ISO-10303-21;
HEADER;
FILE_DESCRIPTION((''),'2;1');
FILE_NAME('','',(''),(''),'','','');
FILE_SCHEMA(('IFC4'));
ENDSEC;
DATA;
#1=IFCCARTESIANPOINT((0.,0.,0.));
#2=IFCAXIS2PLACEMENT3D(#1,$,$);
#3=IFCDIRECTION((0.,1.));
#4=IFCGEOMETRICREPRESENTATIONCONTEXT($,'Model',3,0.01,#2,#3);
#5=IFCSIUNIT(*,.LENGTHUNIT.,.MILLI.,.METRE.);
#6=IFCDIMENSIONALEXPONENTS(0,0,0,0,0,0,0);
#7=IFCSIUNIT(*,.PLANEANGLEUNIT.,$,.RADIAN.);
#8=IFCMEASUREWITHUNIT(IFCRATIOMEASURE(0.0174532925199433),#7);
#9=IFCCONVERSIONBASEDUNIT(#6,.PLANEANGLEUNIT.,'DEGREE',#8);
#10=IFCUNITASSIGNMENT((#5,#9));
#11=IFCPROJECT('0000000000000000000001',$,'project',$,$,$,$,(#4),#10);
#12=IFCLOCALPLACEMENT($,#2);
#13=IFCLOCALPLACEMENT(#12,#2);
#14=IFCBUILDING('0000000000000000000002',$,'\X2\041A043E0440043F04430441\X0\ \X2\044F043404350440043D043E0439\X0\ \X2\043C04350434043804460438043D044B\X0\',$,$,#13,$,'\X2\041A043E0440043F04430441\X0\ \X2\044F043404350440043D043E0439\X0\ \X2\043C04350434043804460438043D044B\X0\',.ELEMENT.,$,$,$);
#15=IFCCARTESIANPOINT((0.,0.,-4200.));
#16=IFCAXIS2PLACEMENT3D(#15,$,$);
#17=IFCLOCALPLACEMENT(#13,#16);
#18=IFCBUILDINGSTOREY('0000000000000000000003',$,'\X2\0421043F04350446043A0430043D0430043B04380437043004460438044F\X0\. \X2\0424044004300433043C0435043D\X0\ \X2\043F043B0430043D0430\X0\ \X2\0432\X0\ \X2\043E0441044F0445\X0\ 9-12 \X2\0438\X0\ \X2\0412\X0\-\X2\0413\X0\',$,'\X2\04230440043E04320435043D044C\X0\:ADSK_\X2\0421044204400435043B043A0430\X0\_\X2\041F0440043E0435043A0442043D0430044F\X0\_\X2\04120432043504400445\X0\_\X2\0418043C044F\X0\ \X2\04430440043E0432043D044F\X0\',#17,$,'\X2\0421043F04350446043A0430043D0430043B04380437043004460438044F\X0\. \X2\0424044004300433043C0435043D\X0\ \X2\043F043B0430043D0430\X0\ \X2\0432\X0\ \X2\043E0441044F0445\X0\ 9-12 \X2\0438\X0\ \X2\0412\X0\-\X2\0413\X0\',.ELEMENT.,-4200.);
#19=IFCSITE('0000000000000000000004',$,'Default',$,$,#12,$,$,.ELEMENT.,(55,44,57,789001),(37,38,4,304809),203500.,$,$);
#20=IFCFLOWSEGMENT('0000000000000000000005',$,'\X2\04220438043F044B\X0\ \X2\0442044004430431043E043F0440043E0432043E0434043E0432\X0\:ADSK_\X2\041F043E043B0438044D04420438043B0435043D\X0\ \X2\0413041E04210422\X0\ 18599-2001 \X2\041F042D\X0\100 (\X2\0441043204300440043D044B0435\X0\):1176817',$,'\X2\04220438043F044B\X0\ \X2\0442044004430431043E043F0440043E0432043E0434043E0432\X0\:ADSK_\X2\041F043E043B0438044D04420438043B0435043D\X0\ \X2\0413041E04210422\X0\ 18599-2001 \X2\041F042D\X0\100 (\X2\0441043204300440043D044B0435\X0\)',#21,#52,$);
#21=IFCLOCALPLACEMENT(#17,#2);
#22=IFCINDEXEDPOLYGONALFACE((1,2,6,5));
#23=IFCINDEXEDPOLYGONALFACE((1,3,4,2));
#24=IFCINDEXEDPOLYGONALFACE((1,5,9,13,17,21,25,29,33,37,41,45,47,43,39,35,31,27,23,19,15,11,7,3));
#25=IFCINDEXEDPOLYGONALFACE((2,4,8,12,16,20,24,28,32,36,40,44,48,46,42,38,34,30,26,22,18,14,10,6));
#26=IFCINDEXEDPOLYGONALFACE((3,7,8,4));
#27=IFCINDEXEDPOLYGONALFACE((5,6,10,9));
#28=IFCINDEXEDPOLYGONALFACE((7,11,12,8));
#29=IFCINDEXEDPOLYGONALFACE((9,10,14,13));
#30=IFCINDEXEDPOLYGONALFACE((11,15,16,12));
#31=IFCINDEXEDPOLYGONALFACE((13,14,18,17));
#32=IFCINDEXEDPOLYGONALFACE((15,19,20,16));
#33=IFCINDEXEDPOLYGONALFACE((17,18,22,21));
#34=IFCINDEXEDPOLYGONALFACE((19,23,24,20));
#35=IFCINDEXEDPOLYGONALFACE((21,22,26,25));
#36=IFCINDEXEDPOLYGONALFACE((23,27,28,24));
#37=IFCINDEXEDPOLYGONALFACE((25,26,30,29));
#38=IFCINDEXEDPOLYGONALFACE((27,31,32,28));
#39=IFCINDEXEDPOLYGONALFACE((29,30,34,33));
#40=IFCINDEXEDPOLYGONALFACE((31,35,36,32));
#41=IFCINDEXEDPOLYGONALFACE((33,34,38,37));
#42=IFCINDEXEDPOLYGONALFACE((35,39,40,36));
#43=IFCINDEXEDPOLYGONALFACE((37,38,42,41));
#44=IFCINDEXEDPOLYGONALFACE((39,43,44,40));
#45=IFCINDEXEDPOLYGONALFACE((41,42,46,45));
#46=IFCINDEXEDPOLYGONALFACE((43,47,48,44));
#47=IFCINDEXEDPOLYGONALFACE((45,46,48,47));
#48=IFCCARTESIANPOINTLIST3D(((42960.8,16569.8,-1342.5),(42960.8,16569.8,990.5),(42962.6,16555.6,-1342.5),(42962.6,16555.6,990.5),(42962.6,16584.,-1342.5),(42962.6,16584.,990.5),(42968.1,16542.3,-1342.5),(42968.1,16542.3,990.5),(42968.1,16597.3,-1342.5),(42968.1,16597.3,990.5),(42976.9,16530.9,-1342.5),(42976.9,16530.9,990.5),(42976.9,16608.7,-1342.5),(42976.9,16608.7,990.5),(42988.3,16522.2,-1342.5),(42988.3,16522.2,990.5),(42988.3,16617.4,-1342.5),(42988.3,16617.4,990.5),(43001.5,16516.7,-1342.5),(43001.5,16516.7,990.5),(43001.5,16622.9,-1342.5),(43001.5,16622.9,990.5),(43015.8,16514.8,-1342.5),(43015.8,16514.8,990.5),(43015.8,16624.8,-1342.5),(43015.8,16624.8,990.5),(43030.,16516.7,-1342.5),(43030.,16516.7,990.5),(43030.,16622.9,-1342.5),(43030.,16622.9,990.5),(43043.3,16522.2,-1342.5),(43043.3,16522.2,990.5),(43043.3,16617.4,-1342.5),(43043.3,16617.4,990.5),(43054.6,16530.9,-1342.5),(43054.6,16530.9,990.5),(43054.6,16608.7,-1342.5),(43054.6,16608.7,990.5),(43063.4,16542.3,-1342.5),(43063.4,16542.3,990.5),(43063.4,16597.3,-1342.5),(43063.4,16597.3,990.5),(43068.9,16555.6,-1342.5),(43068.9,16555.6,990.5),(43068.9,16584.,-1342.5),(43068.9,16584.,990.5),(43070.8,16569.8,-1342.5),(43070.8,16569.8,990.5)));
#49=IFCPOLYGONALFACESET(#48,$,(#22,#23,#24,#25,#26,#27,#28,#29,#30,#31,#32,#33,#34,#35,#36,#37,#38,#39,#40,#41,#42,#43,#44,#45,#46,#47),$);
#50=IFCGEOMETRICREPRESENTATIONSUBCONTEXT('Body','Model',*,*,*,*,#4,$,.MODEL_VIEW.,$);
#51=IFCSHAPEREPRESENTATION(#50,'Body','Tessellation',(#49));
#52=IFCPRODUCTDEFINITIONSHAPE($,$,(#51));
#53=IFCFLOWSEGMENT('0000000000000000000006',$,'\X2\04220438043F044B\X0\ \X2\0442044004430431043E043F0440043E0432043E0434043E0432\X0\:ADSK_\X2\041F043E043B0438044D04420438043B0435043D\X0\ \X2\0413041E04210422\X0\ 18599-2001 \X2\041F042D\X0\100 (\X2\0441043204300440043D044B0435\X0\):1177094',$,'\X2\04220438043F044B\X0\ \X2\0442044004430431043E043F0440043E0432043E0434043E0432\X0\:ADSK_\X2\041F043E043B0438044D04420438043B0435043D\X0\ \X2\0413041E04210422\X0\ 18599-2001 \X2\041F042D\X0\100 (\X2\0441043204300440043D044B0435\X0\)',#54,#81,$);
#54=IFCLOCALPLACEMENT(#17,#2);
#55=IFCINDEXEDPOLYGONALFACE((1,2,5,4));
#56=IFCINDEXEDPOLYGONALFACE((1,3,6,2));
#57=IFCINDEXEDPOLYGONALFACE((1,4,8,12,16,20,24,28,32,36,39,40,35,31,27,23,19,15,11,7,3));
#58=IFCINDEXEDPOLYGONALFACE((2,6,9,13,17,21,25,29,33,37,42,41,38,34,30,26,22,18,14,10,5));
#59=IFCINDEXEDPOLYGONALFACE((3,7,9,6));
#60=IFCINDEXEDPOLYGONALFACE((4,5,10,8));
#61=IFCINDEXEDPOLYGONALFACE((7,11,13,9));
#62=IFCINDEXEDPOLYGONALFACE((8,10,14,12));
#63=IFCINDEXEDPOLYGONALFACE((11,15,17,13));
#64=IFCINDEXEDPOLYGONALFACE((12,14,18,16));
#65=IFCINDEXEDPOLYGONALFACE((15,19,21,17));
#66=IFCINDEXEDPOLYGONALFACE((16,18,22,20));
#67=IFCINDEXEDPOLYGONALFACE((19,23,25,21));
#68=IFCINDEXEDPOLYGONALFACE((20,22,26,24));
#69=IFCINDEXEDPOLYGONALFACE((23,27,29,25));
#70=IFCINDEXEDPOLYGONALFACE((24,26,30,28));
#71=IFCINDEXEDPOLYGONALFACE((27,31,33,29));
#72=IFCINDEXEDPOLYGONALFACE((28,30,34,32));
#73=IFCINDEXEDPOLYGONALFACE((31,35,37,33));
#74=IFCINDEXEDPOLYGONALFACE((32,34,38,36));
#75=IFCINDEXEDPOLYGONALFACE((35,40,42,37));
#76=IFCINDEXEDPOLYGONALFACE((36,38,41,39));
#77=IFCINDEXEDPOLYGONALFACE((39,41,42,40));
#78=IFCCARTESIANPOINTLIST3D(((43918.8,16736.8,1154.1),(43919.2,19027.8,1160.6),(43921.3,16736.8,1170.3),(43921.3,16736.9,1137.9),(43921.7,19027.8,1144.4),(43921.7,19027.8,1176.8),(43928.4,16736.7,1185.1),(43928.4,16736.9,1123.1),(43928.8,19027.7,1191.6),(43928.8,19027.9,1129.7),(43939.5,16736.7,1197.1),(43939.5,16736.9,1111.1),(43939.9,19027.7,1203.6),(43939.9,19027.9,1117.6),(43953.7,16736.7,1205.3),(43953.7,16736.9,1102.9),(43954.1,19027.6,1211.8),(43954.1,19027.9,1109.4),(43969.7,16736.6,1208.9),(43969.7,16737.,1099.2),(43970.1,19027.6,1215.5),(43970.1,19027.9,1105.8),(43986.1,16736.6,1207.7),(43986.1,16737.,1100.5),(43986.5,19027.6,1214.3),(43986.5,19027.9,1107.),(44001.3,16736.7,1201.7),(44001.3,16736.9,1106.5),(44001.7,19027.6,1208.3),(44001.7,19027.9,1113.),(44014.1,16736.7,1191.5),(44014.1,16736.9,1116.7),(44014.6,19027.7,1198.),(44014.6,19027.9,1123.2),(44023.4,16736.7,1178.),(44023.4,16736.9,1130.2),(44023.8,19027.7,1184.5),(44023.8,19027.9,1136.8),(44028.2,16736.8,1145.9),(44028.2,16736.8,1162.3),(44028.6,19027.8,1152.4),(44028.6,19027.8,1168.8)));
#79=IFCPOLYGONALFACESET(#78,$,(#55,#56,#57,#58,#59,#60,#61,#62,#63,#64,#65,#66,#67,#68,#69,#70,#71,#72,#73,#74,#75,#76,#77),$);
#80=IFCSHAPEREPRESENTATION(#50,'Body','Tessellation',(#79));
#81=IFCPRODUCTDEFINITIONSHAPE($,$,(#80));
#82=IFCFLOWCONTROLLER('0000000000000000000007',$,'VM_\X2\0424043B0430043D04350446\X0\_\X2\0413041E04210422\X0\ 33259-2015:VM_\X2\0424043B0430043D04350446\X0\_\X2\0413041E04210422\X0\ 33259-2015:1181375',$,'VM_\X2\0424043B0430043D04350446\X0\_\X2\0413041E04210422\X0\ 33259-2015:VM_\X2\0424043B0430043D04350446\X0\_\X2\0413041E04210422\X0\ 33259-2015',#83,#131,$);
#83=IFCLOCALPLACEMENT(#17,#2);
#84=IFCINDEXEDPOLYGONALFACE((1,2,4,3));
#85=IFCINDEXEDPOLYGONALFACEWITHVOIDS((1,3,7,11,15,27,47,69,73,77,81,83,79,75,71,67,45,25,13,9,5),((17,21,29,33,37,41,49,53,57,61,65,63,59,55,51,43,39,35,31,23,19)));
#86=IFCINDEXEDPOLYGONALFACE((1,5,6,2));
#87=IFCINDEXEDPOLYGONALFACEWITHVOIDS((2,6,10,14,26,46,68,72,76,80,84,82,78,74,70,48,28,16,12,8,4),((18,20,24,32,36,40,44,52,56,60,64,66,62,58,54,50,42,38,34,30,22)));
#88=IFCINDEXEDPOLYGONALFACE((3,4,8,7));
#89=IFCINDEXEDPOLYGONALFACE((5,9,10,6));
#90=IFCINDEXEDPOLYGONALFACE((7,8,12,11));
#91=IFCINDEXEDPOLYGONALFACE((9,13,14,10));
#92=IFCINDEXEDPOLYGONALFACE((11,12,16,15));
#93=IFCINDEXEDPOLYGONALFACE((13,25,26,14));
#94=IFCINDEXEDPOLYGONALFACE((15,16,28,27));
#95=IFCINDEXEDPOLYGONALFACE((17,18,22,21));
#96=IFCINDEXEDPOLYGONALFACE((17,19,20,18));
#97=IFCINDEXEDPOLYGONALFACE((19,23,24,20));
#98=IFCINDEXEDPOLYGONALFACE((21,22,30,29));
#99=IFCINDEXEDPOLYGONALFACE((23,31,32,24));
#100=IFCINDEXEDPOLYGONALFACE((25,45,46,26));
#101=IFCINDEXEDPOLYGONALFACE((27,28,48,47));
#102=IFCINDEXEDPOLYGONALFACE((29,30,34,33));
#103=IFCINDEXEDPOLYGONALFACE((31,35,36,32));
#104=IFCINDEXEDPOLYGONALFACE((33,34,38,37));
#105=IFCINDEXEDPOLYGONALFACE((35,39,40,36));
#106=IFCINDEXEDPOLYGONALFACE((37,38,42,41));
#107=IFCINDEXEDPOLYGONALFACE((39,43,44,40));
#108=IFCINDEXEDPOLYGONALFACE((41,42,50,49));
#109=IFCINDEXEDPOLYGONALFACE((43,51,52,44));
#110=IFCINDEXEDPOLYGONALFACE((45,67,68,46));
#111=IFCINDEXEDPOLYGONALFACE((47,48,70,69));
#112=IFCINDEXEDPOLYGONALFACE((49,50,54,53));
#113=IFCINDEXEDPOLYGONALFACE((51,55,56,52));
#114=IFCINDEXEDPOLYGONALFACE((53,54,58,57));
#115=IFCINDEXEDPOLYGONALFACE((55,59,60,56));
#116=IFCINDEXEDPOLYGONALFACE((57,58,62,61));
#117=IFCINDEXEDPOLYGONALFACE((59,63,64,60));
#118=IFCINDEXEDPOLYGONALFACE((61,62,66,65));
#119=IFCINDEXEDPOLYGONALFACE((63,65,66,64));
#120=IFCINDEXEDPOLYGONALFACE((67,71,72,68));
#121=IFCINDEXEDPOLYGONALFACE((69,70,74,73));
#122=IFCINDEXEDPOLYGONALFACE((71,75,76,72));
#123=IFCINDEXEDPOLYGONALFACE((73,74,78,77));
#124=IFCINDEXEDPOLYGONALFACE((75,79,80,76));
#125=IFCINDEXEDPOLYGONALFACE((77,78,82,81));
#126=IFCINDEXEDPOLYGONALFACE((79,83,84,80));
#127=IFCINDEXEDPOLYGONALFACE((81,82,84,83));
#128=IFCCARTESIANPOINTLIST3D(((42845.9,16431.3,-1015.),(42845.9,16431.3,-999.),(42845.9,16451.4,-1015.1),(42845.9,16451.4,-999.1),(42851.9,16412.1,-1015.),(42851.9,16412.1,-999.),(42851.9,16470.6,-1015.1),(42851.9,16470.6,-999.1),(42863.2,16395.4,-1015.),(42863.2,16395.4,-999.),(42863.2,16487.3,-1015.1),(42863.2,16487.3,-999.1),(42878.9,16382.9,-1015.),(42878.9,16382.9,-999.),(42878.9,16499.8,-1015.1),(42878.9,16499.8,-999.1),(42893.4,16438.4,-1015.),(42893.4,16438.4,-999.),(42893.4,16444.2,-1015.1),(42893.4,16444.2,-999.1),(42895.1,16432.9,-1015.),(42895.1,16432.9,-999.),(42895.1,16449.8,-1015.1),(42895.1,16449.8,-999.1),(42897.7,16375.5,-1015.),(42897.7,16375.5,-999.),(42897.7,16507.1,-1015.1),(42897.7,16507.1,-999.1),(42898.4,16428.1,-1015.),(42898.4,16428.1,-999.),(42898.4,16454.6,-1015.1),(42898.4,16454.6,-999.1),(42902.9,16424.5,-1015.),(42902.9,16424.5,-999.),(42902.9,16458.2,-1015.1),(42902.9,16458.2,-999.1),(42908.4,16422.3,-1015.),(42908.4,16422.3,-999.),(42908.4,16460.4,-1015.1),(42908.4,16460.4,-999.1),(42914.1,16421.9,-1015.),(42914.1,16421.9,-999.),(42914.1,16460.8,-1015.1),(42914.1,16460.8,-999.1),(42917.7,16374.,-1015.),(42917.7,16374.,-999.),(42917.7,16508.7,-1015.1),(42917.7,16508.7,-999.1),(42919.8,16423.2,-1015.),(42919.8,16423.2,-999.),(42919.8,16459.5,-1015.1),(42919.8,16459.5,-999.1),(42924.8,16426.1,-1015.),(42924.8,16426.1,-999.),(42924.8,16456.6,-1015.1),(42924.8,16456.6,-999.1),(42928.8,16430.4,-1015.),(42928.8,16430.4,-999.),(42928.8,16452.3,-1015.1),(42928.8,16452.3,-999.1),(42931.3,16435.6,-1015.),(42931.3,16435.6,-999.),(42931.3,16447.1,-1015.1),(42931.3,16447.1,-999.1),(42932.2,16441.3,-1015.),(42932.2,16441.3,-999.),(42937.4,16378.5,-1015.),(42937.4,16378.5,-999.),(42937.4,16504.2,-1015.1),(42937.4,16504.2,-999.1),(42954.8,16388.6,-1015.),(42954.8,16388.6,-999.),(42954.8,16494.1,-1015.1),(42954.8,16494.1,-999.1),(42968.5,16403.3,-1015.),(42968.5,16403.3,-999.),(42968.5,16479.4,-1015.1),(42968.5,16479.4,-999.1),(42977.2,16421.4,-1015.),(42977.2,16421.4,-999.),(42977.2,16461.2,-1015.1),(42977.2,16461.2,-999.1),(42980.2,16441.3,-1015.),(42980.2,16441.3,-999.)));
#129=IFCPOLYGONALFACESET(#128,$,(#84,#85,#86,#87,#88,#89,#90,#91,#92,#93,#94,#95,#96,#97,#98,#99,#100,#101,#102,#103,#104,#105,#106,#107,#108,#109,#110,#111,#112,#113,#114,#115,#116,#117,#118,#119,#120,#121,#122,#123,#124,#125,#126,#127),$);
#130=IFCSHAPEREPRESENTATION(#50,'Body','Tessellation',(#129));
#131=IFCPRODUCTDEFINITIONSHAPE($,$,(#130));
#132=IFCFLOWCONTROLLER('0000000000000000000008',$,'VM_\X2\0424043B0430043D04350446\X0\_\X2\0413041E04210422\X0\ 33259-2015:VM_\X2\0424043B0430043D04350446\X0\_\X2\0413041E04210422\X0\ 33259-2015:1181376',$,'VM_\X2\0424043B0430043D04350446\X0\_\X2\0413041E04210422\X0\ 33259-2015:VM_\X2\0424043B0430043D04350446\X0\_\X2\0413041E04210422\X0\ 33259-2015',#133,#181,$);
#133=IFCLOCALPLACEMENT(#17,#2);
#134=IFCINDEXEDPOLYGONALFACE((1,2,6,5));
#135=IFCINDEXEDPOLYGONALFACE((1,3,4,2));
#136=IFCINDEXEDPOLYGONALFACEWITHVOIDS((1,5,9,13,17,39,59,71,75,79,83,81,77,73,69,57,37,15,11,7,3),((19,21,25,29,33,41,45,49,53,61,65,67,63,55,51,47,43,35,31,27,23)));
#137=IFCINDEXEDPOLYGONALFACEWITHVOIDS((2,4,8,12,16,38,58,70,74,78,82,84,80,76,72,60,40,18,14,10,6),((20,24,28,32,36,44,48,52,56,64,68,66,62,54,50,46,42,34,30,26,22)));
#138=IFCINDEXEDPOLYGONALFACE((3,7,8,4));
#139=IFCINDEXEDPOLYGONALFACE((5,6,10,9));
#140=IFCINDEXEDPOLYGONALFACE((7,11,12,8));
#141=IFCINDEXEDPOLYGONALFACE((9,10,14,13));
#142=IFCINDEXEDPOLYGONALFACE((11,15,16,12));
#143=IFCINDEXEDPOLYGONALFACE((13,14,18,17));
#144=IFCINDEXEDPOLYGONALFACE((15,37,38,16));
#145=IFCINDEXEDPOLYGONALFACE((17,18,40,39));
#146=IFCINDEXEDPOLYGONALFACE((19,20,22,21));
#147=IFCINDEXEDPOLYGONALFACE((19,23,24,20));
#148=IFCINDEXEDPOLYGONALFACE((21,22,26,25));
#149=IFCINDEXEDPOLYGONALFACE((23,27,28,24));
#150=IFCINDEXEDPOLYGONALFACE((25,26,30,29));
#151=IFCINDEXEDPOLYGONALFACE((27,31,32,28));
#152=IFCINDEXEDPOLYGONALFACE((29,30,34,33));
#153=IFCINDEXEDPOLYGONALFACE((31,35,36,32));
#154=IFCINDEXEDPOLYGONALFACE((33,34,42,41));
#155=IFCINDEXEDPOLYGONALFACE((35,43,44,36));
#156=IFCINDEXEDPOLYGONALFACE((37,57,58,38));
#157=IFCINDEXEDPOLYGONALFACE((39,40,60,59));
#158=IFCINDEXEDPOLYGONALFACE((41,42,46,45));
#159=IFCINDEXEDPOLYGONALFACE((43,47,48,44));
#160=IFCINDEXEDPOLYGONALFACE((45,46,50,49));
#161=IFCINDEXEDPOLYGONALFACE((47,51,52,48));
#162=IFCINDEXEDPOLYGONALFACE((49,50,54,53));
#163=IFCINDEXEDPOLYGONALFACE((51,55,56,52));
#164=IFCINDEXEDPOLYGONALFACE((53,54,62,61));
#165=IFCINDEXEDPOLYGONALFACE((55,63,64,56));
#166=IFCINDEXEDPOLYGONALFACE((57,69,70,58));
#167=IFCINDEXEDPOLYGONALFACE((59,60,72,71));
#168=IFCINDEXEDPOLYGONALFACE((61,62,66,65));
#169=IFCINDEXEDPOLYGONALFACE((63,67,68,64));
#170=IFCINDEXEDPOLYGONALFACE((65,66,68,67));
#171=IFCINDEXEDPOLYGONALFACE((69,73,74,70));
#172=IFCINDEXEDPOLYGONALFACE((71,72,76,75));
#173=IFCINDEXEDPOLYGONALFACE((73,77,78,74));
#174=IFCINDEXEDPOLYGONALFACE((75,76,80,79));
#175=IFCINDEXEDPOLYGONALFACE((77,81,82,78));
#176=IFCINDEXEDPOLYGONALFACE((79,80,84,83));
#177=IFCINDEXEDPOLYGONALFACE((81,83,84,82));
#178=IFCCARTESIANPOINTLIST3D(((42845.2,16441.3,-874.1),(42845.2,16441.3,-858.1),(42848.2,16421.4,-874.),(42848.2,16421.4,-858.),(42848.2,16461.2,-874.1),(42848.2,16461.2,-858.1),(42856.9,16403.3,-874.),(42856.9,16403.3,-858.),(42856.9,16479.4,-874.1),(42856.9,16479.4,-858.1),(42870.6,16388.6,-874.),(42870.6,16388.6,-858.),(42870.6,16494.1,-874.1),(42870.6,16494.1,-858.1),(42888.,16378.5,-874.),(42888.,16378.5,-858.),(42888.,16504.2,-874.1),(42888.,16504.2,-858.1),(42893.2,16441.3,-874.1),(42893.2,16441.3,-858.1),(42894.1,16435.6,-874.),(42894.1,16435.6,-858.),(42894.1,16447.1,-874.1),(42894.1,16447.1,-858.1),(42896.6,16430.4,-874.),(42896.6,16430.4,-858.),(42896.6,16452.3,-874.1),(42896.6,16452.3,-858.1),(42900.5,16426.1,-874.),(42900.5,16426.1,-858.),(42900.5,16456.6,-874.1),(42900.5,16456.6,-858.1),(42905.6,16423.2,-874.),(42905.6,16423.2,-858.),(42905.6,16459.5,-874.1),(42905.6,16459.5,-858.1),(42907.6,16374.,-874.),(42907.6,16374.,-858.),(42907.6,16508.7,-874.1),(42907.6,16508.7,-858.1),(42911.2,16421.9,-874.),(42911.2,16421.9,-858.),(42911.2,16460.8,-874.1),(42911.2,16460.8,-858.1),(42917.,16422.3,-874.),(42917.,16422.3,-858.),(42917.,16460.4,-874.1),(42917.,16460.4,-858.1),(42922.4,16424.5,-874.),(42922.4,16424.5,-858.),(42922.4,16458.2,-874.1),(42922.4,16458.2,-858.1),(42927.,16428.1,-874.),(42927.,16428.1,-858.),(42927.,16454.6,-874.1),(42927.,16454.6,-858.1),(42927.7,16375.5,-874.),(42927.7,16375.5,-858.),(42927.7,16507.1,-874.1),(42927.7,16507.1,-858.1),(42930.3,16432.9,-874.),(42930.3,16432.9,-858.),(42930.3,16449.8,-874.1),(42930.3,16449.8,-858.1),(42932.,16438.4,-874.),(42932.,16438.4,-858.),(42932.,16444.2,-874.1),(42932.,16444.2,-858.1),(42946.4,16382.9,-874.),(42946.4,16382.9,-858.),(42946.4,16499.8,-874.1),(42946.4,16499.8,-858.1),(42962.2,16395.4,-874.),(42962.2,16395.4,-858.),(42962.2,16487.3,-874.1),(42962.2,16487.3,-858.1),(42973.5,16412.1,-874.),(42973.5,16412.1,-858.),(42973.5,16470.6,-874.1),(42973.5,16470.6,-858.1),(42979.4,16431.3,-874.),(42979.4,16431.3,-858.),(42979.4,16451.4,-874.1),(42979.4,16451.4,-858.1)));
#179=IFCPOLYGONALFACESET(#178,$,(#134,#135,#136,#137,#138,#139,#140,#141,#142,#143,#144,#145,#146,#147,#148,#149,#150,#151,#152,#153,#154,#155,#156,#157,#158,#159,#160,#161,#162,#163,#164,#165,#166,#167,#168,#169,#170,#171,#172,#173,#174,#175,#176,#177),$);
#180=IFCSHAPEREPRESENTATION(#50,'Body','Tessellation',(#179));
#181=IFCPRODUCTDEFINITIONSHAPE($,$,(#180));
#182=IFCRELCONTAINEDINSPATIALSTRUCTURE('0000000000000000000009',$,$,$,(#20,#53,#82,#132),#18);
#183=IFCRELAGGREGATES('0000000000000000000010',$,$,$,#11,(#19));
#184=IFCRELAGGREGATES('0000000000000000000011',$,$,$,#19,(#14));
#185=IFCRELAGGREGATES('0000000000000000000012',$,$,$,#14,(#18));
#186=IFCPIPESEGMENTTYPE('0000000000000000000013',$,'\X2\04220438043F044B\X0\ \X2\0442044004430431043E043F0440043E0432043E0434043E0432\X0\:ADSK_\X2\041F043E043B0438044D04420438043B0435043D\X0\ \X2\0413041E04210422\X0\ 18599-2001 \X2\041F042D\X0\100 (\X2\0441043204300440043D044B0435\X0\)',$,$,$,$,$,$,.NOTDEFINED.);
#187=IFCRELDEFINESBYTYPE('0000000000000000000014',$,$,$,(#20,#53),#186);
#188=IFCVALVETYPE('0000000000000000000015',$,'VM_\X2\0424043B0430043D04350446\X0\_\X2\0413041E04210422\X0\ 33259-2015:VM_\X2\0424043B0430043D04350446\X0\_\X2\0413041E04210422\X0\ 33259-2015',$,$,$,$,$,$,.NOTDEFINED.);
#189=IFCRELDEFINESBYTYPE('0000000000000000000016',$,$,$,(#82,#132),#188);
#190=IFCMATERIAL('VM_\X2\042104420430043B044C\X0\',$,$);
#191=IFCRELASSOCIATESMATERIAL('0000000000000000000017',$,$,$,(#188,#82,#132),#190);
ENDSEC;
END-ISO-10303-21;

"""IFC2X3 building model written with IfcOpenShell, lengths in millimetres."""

from ifc_helpers import new_model, entity, si_unit, converted_unit, direction, frame, origin, origin_2d_with_axis, place, context, subcontext, project, spatial, polyline, circle, hollow_circle, outline, extrude, source, transform, mapped, material, type_object, type_shapes, element, save


model = new_model("IFC2X3")

# Units and contexts
model_context = context("Model", 3, precision=0.01, world=origin(), true_north=direction((0.0, 1.0)))
body_context = subcontext(model_context, "Body", "Model", "MODEL_VIEW")
ifc_project = project(units=[si_unit("LENGTHUNIT", "METRE", prefix="MILLI"), converted_unit("PLANEANGLEUNIT", "DEGREE", entity("IfcRatioMeasure", 0.0174532925199433), si_unit("PLANEANGLEUNIT", "RADIAN"), dimensions=[0, 0, 0, 0, 0, 0, 0])], contexts=[model_context])

# Site, building, storey
site_placement = place(None, origin())
site = spatial("IfcSite", under=ifc_project, at=site_placement, Name="Default", CompositionType="ELEMENT", RefLatitude=(55, 44, 57, 789001), RefLongitude=(37, 38, 4, 304809), RefElevation=203500.0)
building_placement = place(site_placement, origin())
building = spatial("IfcBuilding", under=site, at=building_placement, Name="Корпус ядерной медицины", LongName="Корпус ядерной медицины", CompositionType="ELEMENT")
storey_placement = place(building_placement, frame((0.0, 0.0, -4200.0)))
storey = spatial("IfcBuildingStorey", under=building, at=storey_placement, Name="Спецканализация. Фрагмен плана в осях 9-12 и В-Г", ObjectType="Уровень:ADSK_Стрелка_Проектная_Вверх_Имя уровня", LongName="Спецканализация. Фрагмен плана в осях 9-12 и В-Г", CompositionType="ELEMENT", Elevation=-4200.0)

# Flow segments
pipe_segment_type = type_object("IfcPipeSegmentType", Name="Типы трубопроводов:ADSK_Полиэтилен ГОСТ 18599-2001 ПЭ100 (сварные)", PredefinedType="NOTDEFINED")
flow_segment_1_placement = place(storey_placement, frame((42959.2, 16513.2, -1342.5)))
element("IfcFlowSegment", 1, at=flow_segment_1_placement, inside=storey, type_object=pipe_segment_type, Name="Типы трубопроводов:ADSK_Полиэтилен ГОСТ 18599-2001 ПЭ100 (сварные):1176817", ObjectType="Типы трубопроводов:ADSK_Полиэтилен ГОСТ 18599-2001 ПЭ100 (сварные)", context=body_context, shape_type="SweptSolid", body=[
    extrude(outline(polyline([(-7.2, -54.5), (7.2, -54.5), (21.1, -50.8), (33.5, -43.6), (43.6, -33.5), (50.8, -21.1), (54.5, -7.2), (54.5, 7.2), (50.8, 21.1), (43.6, 33.5), (33.5, 43.6), (21.1, 50.8), (7.2, 54.5), (-7.2, 54.5), (-21.1, 50.8), (-33.5, 43.6), (-43.6, 33.5), (-50.8, 21.1), (-54.5, 7.2), (-54.5, -7.2), (-50.8, -21.1), (-43.6, -33.5), (-33.5, -43.6), (-21.1, -50.8), (-7.2, -54.5)])), frame((56.6, 56.6, 0.0), z_axis=(0.0, 0.0, 1.0), x_axis=(-0.130526, 0.991445, 0.0)), (0.0, 0.0, 1.0), 2333.0),
])
flow_segment_2_placement = place(storey_placement, frame((43917.2, 16735.0, 1097.5)))
element("IfcFlowSegment", 2, at=flow_segment_2_placement, inside=storey, type_object=pipe_segment_type, Name="Типы трубопроводов:ADSK_Полиэтилен ГОСТ 18599-2001 ПЭ100 (сварные):1177094", ObjectType="Типы трубопроводов:ADSK_Полиэтилен ГОСТ 18599-2001 ПЭ100 (сварные)", context=body_context, shape_type="SweptSolid", body=[
    extrude(circle(Radius=55.0, at=origin_2d_with_axis()), frame((56.6, 1.8, 56.6), z_axis=(0.00018, 0.999996, 0.002858), x_axis=(-1.0, 0.00018, 0.0)), (0.0, 0.0, 1.0), 2291.0),
])

# Flow controllers
ifc_material_1 = material(Name="VM_Сталь")
valve_type_1 = type_object("IfcValveType", Name="VM_Фланец_ГОСТ 33259-2015:VM_Фланец_ГОСТ 33259-2015", PredefinedType="NOTDEFINED", material=ifc_material_1)
shared_shape_1 = source(origin(), body_context, "Body", "SweptSolid", [
    extrude(hollow_circle(Radius=67.5, WallThickness=48.0, at=origin_2d_with_axis()), frame((0.0, 0.0, 0.0), z_axis=(1.0, 0.0, 0.0), x_axis=(0.0, 1.0, 0.0)), (0.0, 0.0, 1.0), 16.0),
])
type_shapes(valve_type_1, [shared_shape_1])
for number, where, z_axis, x_axis, name in (
    (3, (42912.7, 16441.3, -1015.0), (0.0, 1.0, -0.000001), (0.0, 0.000001, 1.0), "VM_Фланец_ГОСТ 33259-2015:VM_Фланец_ГОСТ 33259-2015:1181375"),
    (4, (42912.7, 16441.3, -858.0), (0.0, 1.0, -0.000001), (0.0, -0.000001, -1.0), "VM_Фланец_ГОСТ 33259-2015:VM_Фланец_ГОСТ 33259-2015:1181376"),
):
    element("IfcFlowController", number, at=place(storey_placement, frame(where, z_axis=z_axis, x_axis=x_axis)), inside=storey, type_object=valve_type_1, material=ifc_material_1, Name=name, ObjectType="VM_Фланец_ГОСТ 33259-2015:VM_Фланец_ГОСТ 33259-2015", context=body_context, shape_type="MappedRepresentation", body=[
        mapped(shared_shape_1, transform((0.0, 0.0, 0.0), scale=1.0)),
    ])

save(model, "model.ifc")
